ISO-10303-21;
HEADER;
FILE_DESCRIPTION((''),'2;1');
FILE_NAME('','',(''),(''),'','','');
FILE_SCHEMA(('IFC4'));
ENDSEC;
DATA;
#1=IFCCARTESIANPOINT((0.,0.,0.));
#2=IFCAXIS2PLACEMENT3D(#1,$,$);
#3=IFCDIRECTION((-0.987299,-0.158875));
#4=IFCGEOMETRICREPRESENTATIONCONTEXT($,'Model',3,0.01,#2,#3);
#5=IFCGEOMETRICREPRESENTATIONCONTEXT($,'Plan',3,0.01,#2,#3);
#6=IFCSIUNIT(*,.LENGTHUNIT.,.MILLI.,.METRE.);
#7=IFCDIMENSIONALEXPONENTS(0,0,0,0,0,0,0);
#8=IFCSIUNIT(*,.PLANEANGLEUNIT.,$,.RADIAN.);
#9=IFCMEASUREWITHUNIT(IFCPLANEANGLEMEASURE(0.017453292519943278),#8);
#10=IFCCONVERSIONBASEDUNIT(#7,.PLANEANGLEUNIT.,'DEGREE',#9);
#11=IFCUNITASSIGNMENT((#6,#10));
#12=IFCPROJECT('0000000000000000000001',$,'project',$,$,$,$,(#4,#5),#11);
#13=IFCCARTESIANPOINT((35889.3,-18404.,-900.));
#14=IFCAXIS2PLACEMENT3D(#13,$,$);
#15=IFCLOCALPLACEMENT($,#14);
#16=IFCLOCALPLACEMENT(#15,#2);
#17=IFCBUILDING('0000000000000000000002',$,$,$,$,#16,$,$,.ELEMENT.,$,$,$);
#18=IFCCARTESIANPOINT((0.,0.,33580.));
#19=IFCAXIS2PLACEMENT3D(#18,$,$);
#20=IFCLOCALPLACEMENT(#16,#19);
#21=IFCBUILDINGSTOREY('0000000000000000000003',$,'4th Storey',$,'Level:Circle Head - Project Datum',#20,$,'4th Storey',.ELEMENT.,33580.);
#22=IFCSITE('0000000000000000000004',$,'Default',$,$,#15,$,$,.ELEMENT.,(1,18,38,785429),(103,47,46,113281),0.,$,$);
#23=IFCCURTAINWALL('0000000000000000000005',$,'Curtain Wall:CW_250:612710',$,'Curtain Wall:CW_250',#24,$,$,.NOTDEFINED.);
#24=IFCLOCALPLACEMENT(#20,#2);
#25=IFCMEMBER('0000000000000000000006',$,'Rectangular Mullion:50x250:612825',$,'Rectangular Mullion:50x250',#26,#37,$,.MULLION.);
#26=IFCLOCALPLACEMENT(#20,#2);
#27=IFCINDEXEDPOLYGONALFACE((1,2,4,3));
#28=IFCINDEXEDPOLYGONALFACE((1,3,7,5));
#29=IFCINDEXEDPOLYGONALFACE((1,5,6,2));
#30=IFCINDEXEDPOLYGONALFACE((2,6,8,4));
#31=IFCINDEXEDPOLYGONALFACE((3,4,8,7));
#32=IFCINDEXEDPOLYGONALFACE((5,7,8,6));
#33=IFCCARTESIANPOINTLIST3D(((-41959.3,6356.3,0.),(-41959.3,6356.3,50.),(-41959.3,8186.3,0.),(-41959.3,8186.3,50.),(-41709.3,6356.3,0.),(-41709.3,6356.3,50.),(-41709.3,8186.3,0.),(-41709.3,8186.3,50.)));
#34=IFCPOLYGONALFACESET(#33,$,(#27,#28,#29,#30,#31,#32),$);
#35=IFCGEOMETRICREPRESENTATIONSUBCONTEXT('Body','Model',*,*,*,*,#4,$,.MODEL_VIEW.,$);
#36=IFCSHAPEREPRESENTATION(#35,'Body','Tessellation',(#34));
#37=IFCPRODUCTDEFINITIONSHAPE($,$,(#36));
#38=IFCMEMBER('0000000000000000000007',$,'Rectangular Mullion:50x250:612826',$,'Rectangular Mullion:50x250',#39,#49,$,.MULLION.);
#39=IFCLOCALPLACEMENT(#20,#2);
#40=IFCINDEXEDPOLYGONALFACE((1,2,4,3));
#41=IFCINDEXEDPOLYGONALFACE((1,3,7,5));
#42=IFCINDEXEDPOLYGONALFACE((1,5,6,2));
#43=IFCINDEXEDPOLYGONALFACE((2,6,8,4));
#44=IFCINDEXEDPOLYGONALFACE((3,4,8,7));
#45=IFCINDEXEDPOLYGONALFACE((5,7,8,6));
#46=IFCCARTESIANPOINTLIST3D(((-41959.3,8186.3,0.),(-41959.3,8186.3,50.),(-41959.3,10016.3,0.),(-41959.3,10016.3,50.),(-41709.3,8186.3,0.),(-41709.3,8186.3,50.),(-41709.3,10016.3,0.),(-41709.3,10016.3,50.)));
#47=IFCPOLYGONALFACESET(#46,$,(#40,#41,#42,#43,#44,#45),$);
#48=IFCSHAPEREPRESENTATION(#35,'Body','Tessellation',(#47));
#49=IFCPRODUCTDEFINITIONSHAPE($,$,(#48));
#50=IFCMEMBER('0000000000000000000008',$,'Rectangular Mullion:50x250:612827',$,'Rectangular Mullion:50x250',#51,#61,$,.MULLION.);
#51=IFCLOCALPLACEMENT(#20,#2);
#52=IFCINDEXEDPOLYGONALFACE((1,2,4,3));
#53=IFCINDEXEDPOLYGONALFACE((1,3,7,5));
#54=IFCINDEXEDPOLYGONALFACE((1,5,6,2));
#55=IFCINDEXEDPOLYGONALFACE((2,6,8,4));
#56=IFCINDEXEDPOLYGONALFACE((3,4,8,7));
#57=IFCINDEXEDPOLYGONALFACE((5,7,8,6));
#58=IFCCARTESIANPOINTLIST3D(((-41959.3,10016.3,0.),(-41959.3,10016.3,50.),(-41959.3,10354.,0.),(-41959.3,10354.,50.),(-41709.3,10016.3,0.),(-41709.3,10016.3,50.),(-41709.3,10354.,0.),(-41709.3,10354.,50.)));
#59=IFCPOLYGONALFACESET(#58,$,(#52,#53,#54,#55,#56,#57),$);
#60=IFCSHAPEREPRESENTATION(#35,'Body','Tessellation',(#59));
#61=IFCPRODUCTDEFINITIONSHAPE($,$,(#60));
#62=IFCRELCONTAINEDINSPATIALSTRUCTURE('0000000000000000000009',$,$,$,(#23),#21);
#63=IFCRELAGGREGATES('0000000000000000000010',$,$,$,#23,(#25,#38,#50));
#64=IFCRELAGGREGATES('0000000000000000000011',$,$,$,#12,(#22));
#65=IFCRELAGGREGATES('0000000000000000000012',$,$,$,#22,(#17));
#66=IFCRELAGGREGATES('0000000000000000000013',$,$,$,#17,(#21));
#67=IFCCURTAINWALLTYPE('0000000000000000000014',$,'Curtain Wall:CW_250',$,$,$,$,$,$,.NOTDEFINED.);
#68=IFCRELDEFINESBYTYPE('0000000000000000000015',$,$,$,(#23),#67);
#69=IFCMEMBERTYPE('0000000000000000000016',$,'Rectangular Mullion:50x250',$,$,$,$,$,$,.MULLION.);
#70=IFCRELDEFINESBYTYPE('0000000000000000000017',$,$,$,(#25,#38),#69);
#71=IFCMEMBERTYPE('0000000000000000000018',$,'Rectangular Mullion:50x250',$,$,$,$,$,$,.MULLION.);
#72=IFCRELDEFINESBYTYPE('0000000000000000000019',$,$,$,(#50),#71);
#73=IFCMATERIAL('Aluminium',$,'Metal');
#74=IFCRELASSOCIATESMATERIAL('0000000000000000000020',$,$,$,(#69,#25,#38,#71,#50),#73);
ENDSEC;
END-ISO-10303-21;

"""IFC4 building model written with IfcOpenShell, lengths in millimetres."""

from ifc_helpers import new_model, entity, si_unit, converted_unit, direction, frame, origin, place, context, subcontext, project, spatial, indexed_curve, outline, extrude, source, transform, mapped, material, type_object, type_shapes, element, aggregate, save


model = new_model("IFC4")

# Units and contexts
model_context = context("Model", 3, precision=0.01, world=origin(), true_north=direction((-0.987299, -0.158875)))
plan_context = context("Plan", 3, precision=0.01, world=origin(), true_north=direction((-0.987299, -0.158875)))
body_context = subcontext(model_context, "Body", "Model", "MODEL_VIEW")
ifc_project = project(units=[si_unit("LENGTHUNIT", "METRE", prefix="MILLI"), converted_unit("PLANEANGLEUNIT", "DEGREE", entity("IfcPlaneAngleMeasure", 0.017453292519943278), si_unit("PLANEANGLEUNIT", "RADIAN"), dimensions=[0, 0, 0, 0, 0, 0, 0])], contexts=[model_context, plan_context])

# Site, building, storey
site_placement = place(None, frame((35889.3, -18404.0, -900.0)))
site = spatial("IfcSite", under=ifc_project, at=site_placement, Name="Default", CompositionType="ELEMENT", RefLatitude=(1, 18, 38, 785429), RefLongitude=(103, 47, 46, 113281), RefElevation=0.0)
building_placement = place(site_placement, origin())
building = spatial("IfcBuilding", under=site, at=building_placement, CompositionType="ELEMENT")
storey_placement = place(building_placement, frame((0.0, 0.0, 33580.0)))
storey = spatial("IfcBuildingStorey", under=building, at=storey_placement, Name="4th Storey", ObjectType="Level:Circle Head - Project Datum", LongName="4th Storey", CompositionType="ELEMENT", Elevation=33580.0)

# Curtain wall, members
curtain_wall_type = type_object("IfcCurtainWallType", Name="Curtain Wall:CW_250", PredefinedType="NOTDEFINED")
curtain_wall_1_placement = place(storey_placement, frame((0.0, 0.0, -33580.0)))
curtain_wall_1 = element("IfcCurtainWall", 1, at=curtain_wall_1_placement, inside=storey, type_object=curtain_wall_type, Name="Curtain Wall:CW_250:612710", ObjectType="Curtain Wall:CW_250", PredefinedType="NOTDEFINED")
ifc_material_1 = material(Name="Aluminium", Category="Metal")
member_type_1 = type_object("IfcMemberType", Name="Rectangular Mullion:50x250", PredefinedType="MULLION", material=ifc_material_1)
shared_shape_1 = source(origin(), body_context, "Body", "SweptSolid", [
    extrude(outline(indexed_curve([(-25.0, -125.0), (25.0, -125.0), (25.0, 125.0), (-25.0, 125.0), (-25.0, -125.0)], self_intersect=False)), frame((-25.0, -125.0, -1830.0), z_axis=(0.0, 0.0, 1.0), x_axis=(-1.0, 0.0, 0.0)), (0.0, 0.0, 1.0), 1830.0),
])
type_shapes(member_type_1, [shared_shape_1])
member_1_placement = place(curtain_wall_1_placement, frame((-41709.3, 6356.3, 33580.0), z_axis=(0.0, -1.0, 0.0), x_axis=(0.0, 0.0, -1.0)))
member_1 = element("IfcMember", 2, at=member_1_placement, type_object=member_type_1, material=ifc_material_1, Name="Rectangular Mullion:50x250:612825", ObjectType="Rectangular Mullion:50x250", PredefinedType="MULLION", context=body_context, shape_type="MappedRepresentation", body=[
    mapped(shared_shape_1, transform((0.0, 0.0, 0.0), scale=1.0)),
])
member_2_placement = place(curtain_wall_1_placement, frame((-41709.3, 8186.3, 33580.0), z_axis=(0.0, -1.0, 0.0), x_axis=(0.0, 0.0, -1.0)))
member_2 = element("IfcMember", 3, at=member_2_placement, type_object=member_type_1, material=ifc_material_1, Name="Rectangular Mullion:50x250:612826", ObjectType="Rectangular Mullion:50x250", PredefinedType="MULLION", context=body_context, shape_type="MappedRepresentation", body=[
    mapped(shared_shape_1, transform((0.0, 0.0, 0.0), scale=1.0)),
])
member_type_2 = type_object("IfcMemberType", Name="Rectangular Mullion:50x250", PredefinedType="MULLION", material=ifc_material_1)
shared_shape_2 = source(origin(), body_context, "Body", "SweptSolid", [
    extrude(outline(indexed_curve([(-25.0, -125.0), (25.0, -125.0), (25.0, 125.0), (-25.0, 125.0), (-25.0, -125.0)], self_intersect=False)), frame((-25.0, -125.0, -337.7), z_axis=(0.0, 0.0, 1.0), x_axis=(-1.0, 0.0, 0.0)), (0.0, 0.0, 1.0), 337.7),
])
type_shapes(member_type_2, [shared_shape_2])
member_3_placement = place(curtain_wall_1_placement, frame((-41709.3, 10016.3, 33580.0), z_axis=(0.0, -1.0, 0.0), x_axis=(0.0, 0.0, -1.0)))
member_3 = element("IfcMember", 4, at=member_3_placement, type_object=member_type_2, material=ifc_material_1, Name="Rectangular Mullion:50x250:612827", ObjectType="Rectangular Mullion:50x250", PredefinedType="MULLION", context=body_context, shape_type="MappedRepresentation", body=[
    mapped(shared_shape_2, transform((0.0, 0.0, 0.0), scale=1.0)),
])
aggregate(curtain_wall_1, [member_1, member_2, member_3])

save(model, "model.ifc")
